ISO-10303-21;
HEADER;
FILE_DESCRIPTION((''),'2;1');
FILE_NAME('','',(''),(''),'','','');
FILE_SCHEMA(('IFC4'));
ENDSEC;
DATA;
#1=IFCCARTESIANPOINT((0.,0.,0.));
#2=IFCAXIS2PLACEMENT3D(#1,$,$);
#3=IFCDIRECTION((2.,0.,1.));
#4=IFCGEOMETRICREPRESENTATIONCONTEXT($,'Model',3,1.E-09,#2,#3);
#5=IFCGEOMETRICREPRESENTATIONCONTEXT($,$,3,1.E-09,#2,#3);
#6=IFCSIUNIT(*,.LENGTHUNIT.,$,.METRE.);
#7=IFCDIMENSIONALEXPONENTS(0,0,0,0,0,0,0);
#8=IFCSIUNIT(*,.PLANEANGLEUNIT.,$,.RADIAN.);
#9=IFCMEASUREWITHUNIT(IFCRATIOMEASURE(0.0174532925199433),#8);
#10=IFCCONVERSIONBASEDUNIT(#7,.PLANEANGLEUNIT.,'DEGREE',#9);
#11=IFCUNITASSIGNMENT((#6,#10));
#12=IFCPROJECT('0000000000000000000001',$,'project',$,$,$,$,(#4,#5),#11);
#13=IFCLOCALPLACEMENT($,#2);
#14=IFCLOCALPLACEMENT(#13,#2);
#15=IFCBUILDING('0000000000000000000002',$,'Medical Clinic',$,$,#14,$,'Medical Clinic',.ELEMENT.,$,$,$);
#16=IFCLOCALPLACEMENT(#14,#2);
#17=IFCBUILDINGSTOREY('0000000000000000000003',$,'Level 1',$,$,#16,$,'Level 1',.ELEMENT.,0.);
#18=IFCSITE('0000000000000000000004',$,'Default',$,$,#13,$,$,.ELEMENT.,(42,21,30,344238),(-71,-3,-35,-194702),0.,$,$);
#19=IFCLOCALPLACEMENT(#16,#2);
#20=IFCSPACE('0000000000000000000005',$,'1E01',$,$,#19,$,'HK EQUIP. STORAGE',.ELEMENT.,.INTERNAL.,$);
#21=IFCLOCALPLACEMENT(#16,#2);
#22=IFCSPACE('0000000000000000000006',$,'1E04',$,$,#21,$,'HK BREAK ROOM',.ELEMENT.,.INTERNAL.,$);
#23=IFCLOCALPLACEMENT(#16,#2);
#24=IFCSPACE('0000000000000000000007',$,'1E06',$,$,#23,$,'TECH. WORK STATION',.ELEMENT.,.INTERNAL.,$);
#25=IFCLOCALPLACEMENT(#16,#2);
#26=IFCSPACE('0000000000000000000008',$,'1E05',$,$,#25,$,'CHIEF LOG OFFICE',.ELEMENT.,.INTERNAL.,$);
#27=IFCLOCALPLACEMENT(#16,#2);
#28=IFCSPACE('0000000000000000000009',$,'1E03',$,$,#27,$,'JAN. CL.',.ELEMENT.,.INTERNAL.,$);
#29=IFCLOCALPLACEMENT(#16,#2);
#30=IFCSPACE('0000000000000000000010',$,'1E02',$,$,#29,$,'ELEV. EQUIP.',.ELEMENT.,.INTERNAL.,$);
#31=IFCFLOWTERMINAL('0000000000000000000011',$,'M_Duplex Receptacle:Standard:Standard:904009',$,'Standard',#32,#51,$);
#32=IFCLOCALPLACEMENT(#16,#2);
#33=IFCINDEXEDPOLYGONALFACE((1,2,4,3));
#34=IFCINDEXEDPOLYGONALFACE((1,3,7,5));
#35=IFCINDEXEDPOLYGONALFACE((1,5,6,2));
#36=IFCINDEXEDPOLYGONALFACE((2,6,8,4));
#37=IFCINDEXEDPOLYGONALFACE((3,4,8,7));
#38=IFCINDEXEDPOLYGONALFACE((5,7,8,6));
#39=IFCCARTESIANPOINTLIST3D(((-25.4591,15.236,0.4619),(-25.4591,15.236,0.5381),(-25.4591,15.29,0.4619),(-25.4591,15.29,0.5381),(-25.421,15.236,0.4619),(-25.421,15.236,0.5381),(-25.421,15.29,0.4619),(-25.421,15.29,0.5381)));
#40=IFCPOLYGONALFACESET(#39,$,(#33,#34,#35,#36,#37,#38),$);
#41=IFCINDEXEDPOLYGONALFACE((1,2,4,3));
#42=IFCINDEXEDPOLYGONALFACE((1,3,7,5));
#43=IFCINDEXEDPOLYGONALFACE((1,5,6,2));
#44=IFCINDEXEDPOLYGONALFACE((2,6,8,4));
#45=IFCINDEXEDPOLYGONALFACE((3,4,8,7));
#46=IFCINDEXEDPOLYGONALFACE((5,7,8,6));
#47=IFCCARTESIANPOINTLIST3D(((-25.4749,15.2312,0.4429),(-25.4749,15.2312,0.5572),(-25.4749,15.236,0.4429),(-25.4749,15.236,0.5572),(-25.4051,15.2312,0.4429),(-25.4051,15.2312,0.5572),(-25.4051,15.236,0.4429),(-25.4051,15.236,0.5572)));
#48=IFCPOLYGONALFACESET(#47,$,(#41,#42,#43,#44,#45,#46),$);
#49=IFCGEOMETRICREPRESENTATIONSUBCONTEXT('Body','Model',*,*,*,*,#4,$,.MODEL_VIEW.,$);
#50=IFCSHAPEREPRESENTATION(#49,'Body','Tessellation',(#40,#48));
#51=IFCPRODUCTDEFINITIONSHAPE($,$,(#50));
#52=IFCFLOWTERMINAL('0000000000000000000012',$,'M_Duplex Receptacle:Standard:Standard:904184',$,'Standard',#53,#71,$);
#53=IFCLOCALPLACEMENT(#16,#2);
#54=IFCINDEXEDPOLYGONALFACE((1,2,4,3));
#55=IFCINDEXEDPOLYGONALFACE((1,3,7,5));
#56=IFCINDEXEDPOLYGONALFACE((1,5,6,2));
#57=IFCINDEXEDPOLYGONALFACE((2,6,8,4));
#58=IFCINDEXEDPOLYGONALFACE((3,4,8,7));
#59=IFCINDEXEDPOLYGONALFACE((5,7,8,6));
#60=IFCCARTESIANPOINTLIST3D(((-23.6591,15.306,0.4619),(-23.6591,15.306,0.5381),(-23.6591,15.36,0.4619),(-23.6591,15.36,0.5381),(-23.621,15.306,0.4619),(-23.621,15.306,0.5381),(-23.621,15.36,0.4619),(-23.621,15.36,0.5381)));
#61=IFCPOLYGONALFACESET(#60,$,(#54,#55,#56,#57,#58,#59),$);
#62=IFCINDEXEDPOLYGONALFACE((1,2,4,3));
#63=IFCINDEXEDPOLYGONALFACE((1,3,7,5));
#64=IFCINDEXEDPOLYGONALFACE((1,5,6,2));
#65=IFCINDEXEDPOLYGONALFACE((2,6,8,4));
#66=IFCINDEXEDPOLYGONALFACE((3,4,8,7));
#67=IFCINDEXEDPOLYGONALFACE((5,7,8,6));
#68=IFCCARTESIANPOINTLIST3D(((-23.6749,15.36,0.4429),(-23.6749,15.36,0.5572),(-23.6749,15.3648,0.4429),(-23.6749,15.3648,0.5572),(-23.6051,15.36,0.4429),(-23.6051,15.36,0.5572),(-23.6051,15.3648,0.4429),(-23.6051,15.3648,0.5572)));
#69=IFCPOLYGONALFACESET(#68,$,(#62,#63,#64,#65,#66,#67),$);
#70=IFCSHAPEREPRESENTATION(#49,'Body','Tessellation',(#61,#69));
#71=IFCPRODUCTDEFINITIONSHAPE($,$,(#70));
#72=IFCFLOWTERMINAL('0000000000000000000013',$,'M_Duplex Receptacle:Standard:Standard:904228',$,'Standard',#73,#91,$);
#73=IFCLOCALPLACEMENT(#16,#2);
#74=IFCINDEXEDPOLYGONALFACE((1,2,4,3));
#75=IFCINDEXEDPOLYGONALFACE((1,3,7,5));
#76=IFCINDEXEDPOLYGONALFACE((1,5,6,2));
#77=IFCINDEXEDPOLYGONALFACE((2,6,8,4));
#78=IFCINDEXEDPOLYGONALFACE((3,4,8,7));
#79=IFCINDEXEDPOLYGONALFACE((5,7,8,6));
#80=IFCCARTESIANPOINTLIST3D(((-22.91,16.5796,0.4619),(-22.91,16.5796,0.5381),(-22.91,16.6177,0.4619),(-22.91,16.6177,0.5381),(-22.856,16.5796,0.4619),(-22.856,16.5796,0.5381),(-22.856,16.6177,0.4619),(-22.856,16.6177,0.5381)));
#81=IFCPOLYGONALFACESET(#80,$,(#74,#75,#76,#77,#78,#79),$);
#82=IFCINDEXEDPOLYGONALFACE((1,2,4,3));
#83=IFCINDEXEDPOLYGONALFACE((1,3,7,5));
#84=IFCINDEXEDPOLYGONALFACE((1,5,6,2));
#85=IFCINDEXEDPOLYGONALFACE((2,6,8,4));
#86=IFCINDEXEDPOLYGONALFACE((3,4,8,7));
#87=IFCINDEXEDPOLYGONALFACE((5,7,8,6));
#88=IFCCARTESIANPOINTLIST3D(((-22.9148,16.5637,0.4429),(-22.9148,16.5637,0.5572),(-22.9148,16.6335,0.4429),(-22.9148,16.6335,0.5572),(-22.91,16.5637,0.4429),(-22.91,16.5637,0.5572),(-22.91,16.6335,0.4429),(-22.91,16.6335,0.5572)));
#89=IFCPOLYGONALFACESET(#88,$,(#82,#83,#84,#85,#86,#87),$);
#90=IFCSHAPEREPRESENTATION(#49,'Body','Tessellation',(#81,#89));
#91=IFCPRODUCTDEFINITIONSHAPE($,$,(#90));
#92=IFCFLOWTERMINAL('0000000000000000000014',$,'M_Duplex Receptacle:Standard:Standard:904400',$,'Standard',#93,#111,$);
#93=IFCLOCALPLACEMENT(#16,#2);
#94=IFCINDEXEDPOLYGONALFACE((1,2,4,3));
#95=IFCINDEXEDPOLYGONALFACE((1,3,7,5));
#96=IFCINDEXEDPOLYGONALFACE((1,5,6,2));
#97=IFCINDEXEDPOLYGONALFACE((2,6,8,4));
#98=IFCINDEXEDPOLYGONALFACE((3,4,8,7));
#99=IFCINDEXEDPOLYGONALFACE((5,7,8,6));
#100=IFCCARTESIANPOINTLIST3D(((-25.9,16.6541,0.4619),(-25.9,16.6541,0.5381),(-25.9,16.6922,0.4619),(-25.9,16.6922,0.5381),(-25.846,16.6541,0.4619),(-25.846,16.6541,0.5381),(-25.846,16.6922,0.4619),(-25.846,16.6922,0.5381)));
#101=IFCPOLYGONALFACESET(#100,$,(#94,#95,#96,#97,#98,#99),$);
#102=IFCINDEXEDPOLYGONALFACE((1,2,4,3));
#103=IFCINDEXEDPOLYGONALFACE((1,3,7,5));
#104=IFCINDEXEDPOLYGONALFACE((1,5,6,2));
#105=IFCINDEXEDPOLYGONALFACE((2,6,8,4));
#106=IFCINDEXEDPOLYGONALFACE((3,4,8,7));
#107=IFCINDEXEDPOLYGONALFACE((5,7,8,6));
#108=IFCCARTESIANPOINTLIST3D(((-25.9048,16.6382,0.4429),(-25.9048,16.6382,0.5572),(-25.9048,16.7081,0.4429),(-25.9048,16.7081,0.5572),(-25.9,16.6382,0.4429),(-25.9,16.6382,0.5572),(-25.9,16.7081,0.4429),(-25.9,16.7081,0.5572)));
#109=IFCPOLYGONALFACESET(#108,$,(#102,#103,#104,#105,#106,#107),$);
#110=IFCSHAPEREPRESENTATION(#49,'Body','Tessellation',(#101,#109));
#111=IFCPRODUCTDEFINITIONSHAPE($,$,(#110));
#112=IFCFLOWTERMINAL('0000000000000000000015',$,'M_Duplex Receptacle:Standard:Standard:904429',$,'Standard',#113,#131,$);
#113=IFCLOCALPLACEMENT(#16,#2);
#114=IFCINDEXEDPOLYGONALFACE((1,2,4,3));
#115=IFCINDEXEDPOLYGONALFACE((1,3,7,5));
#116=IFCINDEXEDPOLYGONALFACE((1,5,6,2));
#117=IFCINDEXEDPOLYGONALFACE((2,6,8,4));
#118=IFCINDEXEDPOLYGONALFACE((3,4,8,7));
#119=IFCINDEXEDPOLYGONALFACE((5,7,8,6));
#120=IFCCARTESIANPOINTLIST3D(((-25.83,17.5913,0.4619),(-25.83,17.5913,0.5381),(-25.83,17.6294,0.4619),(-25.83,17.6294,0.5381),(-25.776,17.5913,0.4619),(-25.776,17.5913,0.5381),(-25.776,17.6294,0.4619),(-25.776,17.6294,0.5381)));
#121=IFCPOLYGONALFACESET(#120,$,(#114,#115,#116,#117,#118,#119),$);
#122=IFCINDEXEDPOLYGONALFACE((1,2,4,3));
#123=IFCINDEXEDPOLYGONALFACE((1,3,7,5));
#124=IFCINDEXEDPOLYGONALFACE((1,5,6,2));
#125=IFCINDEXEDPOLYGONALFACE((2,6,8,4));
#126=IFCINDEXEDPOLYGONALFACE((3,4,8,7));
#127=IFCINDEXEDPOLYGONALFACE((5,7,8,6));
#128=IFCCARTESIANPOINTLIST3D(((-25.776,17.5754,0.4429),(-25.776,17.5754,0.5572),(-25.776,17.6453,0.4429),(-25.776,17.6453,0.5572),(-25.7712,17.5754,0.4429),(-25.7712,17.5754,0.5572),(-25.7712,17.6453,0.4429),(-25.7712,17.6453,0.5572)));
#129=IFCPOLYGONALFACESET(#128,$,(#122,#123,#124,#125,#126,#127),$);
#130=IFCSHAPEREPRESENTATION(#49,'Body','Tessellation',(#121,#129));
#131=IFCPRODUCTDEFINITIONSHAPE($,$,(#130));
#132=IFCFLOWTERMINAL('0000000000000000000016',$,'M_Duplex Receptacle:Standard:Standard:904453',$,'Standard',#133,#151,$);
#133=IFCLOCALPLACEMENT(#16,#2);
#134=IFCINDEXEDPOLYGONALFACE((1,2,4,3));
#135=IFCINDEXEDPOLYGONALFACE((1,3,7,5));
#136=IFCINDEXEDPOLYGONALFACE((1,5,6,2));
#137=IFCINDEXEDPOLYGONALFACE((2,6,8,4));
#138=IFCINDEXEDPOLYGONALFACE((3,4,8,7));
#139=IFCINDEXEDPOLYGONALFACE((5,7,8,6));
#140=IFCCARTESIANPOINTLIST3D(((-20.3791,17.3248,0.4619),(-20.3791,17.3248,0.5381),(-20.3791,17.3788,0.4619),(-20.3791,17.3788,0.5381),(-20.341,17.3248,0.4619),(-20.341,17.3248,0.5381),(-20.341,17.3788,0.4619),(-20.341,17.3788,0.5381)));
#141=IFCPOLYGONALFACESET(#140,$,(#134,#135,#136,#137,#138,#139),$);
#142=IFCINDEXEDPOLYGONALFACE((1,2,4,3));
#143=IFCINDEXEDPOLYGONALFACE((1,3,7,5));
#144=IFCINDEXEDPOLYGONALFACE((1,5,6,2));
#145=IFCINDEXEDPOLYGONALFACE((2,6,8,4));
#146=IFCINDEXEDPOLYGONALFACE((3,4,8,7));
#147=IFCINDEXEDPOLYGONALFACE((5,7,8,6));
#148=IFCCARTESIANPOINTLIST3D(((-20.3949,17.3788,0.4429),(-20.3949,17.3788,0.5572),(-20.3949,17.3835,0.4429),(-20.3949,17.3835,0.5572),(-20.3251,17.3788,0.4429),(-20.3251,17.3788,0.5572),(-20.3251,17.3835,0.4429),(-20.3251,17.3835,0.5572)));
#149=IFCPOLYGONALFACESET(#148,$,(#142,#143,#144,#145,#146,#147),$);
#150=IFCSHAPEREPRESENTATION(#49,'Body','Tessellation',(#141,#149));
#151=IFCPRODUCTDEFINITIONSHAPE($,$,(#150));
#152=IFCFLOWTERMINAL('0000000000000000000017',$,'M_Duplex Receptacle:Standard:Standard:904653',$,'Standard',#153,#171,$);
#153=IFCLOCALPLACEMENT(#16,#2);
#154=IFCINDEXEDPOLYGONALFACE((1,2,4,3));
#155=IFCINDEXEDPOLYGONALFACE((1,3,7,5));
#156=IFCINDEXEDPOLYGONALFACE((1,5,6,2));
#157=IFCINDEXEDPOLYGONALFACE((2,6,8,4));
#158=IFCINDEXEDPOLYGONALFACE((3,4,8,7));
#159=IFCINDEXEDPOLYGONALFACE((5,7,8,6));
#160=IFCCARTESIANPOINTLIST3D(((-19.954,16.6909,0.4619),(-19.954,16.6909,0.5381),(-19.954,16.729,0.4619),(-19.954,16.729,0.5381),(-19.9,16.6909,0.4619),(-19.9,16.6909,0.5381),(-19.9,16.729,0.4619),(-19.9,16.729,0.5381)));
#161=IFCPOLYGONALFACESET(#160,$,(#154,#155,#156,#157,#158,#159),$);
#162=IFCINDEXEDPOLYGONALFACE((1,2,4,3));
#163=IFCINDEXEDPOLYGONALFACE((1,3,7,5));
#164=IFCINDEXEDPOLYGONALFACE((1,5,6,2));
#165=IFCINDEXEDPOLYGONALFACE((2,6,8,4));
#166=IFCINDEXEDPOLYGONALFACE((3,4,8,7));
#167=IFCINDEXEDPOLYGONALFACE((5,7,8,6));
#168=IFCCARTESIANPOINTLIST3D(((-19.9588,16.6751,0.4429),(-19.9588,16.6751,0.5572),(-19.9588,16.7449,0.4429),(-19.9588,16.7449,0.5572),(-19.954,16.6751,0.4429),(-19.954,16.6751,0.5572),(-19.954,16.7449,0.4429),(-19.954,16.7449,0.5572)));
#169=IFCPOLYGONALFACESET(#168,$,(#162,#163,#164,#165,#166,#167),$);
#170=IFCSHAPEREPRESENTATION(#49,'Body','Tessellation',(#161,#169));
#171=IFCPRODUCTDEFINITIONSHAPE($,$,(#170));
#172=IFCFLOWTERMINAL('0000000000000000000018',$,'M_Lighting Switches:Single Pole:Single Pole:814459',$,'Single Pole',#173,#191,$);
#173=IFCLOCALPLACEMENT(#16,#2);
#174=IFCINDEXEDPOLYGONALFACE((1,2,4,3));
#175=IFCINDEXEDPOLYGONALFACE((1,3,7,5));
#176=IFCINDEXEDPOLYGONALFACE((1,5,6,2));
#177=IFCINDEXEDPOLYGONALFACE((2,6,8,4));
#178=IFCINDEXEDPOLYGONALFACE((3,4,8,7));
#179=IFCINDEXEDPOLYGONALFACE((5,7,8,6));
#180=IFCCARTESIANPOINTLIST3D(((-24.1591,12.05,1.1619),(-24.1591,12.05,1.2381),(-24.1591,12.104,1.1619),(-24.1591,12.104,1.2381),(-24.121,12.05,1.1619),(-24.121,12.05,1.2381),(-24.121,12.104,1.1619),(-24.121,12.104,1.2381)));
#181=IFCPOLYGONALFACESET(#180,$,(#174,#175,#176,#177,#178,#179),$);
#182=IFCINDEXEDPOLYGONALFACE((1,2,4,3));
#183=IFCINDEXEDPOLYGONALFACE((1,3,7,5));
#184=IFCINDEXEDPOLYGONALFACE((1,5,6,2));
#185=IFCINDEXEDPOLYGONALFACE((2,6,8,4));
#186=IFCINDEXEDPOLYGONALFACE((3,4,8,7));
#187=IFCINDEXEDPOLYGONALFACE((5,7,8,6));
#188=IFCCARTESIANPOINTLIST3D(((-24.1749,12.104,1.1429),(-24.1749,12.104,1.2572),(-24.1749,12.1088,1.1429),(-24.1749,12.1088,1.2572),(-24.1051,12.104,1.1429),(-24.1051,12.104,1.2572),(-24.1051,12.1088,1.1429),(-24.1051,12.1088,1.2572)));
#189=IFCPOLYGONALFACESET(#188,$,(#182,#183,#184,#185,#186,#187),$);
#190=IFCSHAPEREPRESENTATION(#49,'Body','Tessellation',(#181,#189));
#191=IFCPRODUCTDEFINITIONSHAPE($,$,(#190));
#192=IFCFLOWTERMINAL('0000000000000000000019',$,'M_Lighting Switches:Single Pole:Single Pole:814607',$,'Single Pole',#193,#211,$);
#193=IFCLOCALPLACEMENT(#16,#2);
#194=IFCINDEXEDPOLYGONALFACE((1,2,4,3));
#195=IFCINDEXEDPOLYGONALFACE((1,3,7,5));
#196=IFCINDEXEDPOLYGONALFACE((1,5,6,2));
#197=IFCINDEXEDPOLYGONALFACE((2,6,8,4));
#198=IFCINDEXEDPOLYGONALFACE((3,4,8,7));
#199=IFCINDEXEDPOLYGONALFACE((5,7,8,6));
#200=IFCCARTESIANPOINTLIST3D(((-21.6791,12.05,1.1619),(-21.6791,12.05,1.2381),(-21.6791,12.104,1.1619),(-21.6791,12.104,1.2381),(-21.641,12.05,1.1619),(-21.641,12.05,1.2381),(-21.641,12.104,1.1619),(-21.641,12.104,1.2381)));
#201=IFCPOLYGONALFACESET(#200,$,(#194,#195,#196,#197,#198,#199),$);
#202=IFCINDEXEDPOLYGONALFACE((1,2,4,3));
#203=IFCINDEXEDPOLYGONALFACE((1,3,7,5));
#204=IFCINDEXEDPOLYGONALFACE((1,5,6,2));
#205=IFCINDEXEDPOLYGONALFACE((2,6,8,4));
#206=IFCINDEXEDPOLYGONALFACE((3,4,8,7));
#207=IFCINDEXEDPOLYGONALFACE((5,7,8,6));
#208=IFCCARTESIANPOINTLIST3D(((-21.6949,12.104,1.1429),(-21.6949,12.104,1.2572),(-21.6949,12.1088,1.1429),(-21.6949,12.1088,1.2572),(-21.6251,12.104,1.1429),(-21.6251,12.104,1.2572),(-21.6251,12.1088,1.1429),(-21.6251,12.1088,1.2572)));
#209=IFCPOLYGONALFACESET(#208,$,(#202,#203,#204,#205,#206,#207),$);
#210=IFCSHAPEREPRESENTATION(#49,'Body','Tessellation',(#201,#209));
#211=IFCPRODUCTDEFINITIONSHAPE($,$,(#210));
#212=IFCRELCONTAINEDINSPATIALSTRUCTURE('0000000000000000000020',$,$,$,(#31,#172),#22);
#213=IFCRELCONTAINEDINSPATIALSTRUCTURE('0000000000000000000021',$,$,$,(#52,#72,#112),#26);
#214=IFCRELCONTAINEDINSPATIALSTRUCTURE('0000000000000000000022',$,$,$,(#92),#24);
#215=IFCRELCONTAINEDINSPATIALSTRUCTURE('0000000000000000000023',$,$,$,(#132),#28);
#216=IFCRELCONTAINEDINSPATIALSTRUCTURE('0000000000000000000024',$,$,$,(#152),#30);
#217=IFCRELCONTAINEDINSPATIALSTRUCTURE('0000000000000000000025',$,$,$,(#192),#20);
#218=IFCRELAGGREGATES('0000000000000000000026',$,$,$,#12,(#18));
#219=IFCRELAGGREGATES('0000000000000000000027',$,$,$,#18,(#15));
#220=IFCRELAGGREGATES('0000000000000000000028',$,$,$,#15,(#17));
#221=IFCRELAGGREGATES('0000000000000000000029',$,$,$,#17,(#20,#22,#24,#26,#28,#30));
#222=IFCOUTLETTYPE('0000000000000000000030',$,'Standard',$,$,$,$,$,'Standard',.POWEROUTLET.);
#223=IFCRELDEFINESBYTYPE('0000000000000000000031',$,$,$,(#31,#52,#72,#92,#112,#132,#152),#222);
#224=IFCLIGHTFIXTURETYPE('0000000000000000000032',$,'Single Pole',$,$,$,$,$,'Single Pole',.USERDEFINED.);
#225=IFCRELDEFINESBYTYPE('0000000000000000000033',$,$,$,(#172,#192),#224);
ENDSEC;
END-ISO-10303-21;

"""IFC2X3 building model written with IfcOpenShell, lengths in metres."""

from ifc_helpers import new_model, entity, si_unit, converted_unit, direction, frame, frame_2d, origin, origin_2d_with_axis, place, context, subcontext, project, spatial, rectangle, extrude, source, transform, mapped, type_object, type_shapes, element, save


model = new_model("IFC2X3")

# Units and contexts
model_context = context("Model", 3, precision=1e-09, world=origin(), true_north=direction((2.0, 0.0, 1.0)))
context_of_model = context(None, 3, precision=1e-09, world=origin(), true_north=direction((2.0, 0.0, 1.0)))
body_context = subcontext(model_context, "Body", "Model", "MODEL_VIEW")
ifc_project = project(units=[si_unit("LENGTHUNIT", "METRE"), converted_unit("PLANEANGLEUNIT", "DEGREE", entity("IfcRatioMeasure", 0.0174532925199433), si_unit("PLANEANGLEUNIT", "RADIAN"), dimensions=[0, 0, 0, 0, 0, 0, 0])], contexts=[model_context, context_of_model])

# Site, building, storey
site_placement = place(None, origin())
site = spatial("IfcSite", under=ifc_project, at=site_placement, Name="Default", CompositionType="ELEMENT", RefLatitude=(42, 21, 30, 344238), RefLongitude=(-71, -3, -35, -194702), RefElevation=0.0)
building_placement = place(site_placement, origin())
building = spatial("IfcBuilding", under=site, at=building_placement, Name="Medical Clinic", LongName="Medical Clinic", CompositionType="ELEMENT")
storey_placement = place(building_placement, origin())
storey = spatial("IfcBuildingStorey", under=building, at=storey_placement, Name="Level 1", LongName="Level 1", CompositionType="ELEMENT", Elevation=0.0)

# Shared definitions
outlet_type = type_object("IfcOutletType", Name="Standard", ElementType="Standard", PredefinedType="POWEROUTLET")
shared_shape_1 = source(origin(), body_context, "Body", "SweptSolid", [
    extrude(rectangle(XDim=0.0381, YDim=0.0762, at=origin_2d_with_axis()), frame((0.0, 0.0, -0.054), z_axis=(0.0, 0.0, 1.0), x_axis=(-1.0, 0.0, 0.0)), (0.0, 0.0, 1.0), 0.054),
    extrude(rectangle(XDim=0.0698, YDim=0.1143, at=frame_2d((0.0, 0.0), x_axis=(1.0, 0.0))), frame((0.0, 0.0, 0.0), z_axis=(0.0, 0.0, 1.0), x_axis=(-1.0, 0.0, 0.0)), (0.0, 0.0, 1.0), 0.0048),
])
type_shapes(outlet_type, [shared_shape_1])

# Shared definitions
space_1_placement = place(storey_placement, origin())
space_1 = spatial("IfcSpace", under=storey, at=space_1_placement, Name="1E01", LongName="HK EQUIP. STORAGE", CompositionType="ELEMENT", InteriorOrExteriorSpace="INTERNAL")

# Shared definitions
space_2_placement = place(storey_placement, origin())
space_2 = spatial("IfcSpace", under=storey, at=space_2_placement, Name="1E04", LongName="HK BREAK ROOM", CompositionType="ELEMENT", InteriorOrExteriorSpace="INTERNAL")

# Shared definitions
space_3_placement = place(storey_placement, origin())
space_3 = spatial("IfcSpace", under=storey, at=space_3_placement, Name="1E06", LongName="TECH. WORK STATION", CompositionType="ELEMENT", InteriorOrExteriorSpace="INTERNAL")

# Flow terminal
for number, where, z_axis, x_axis, name in (
    (1, (-25.44, 15.236, 0.5), (0.0, -1.0, 0.0), (1.0, 0.0, 0.0), "M_Duplex Receptacle:Standard:Standard:904009"),
):
    element("IfcFlowTerminal", number, at=place(space_2_placement, frame(where, z_axis=z_axis, x_axis=x_axis)), inside=space_2, type_object=outlet_type, Name=name, ObjectType="Standard", context=body_context, shape_type="MappedRepresentation", body=[
        mapped(shared_shape_1, transform((0.0, 0.0, 0.0), scale=1.0)),
    ])

# Shared definitions
space_4_placement = place(storey_placement, origin())
space_4 = spatial("IfcSpace", under=storey, at=space_4_placement, Name="1E05", LongName="CHIEF LOG OFFICE", CompositionType="ELEMENT", InteriorOrExteriorSpace="INTERNAL")

# Flow terminals
for number, where, z_axis, x_axis, name in (
    (2, (-23.64, 15.36, 0.5), (0.0, 1.0, 0.0), (-1.0, 0.0, 0.0), "M_Duplex Receptacle:Standard:Standard:904184"),
    (3, (-22.91, 16.5986, 0.5), (-1.0, 0.0, 0.0), (0.0, -1.0, 0.0), "M_Duplex Receptacle:Standard:Standard:904228"),
):
    element("IfcFlowTerminal", number, at=place(space_4_placement, frame(where, z_axis=z_axis, x_axis=x_axis)), inside=space_4, type_object=outlet_type, Name=name, ObjectType="Standard", context=body_context, shape_type="MappedRepresentation", body=[
        mapped(shared_shape_1, transform((0.0, 0.0, 0.0), scale=1.0)),
    ])
flow_terminal_1_placement = place(space_3_placement, frame((-25.9, 16.6732, 0.5), z_axis=(-1.0, 0.0, 0.0), x_axis=(0.0, -1.0, 0.0)))
element("IfcFlowTerminal", 4, at=flow_terminal_1_placement, inside=space_3, type_object=outlet_type, Name="M_Duplex Receptacle:Standard:Standard:904400", ObjectType="Standard", context=body_context, shape_type="MappedRepresentation", body=[
    mapped(shared_shape_1, transform((0.0, 0.0, 0.0), scale=1.0)),
])
flow_terminal_2_placement = place(space_4_placement, frame((-25.776, 17.6103, 0.5), z_axis=(1.0, 0.0, 0.0), x_axis=(0.0, 1.0, 0.0)))
element("IfcFlowTerminal", 5, at=flow_terminal_2_placement, inside=space_4, type_object=outlet_type, Name="M_Duplex Receptacle:Standard:Standard:904429", ObjectType="Standard", context=body_context, shape_type="MappedRepresentation", body=[
    mapped(shared_shape_1, transform((0.0, 0.0, 0.0), scale=1.0)),
])

# Shared definitions
space_5_placement = place(storey_placement, origin())
space_5 = spatial("IfcSpace", under=storey, at=space_5_placement, Name="1E03", LongName="JAN. CL.", CompositionType="ELEMENT", InteriorOrExteriorSpace="INTERNAL")

# Flow terminal
flow_terminal_3_placement = place(space_5_placement, frame((-20.36, 17.3788, 0.5), z_axis=(0.0, 1.0, 0.0), x_axis=(-1.0, 0.0, 0.0)))
element("IfcFlowTerminal", 6, at=flow_terminal_3_placement, inside=space_5, type_object=outlet_type, Name="M_Duplex Receptacle:Standard:Standard:904453", ObjectType="Standard", context=body_context, shape_type="MappedRepresentation", body=[
    mapped(shared_shape_1, transform((0.0, 0.0, 0.0), scale=1.0)),
])

# Shared definitions
space_6_placement = place(storey_placement, origin())
space_6 = spatial("IfcSpace", under=storey, at=space_6_placement, Name="1E02", LongName="ELEV. EQUIP.", CompositionType="ELEMENT", InteriorOrExteriorSpace="INTERNAL")

# Flow terminals
flow_terminal_4_placement = place(space_6_placement, frame((-19.954, 16.71, 0.5), z_axis=(-1.0, 0.0, 0.0), x_axis=(0.0, -1.0, 0.0)))
element("IfcFlowTerminal", 7, at=flow_terminal_4_placement, inside=space_6, type_object=outlet_type, Name="M_Duplex Receptacle:Standard:Standard:904653", ObjectType="Standard", context=body_context, shape_type="MappedRepresentation", body=[
    mapped(shared_shape_1, transform((0.0, 0.0, 0.0), scale=1.0)),
])
light_fixture_type_1 = type_object("IfcLightFixtureType", Name="Single Pole", ElementType="Single Pole", PredefinedType="USERDEFINED")
shared_shape_2 = source(origin(), body_context, "Body", "SweptSolid", [
    extrude(rectangle(XDim=0.0381, YDim=0.0762, at=origin_2d_with_axis()), frame((0.0, 0.0, -0.054), z_axis=(0.0, 0.0, 1.0), x_axis=(-1.0, 0.0, 0.0)), (0.0, 0.0, 1.0), 0.054),
    extrude(rectangle(XDim=0.0698, YDim=0.1143, at=frame_2d((0.0, 0.0), x_axis=(1.0, 0.0))), frame((0.0, 0.0, 0.0), z_axis=(0.0, 0.0, 1.0), x_axis=(-1.0, 0.0, 0.0)), (0.0, 0.0, 1.0), 0.0048),
])
type_shapes(light_fixture_type_1, [shared_shape_2])
flow_terminal_5_placement = place(space_2_placement, frame((-24.14, 12.104, 1.2), z_axis=(0.0, 1.0, 0.0), x_axis=(-1.0, 0.0, 0.0)))
element("IfcFlowTerminal", 8, at=flow_terminal_5_placement, inside=space_2, type_object=light_fixture_type_1, Name="M_Lighting Switches:Single Pole:Single Pole:814459", ObjectType="Single Pole", context=body_context, shape_type="MappedRepresentation", body=[
    mapped(shared_shape_2, transform((0.0, 0.0, 0.0), scale=1.0)),
])
flow_terminal_6_placement = place(space_1_placement, frame((-21.66, 12.104, 1.2), z_axis=(0.0, 1.0, 0.0), x_axis=(-1.0, 0.0, 0.0)))
element("IfcFlowTerminal", 9, at=flow_terminal_6_placement, inside=space_1, type_object=light_fixture_type_1, Name="M_Lighting Switches:Single Pole:Single Pole:814607", ObjectType="Single Pole", context=body_context, shape_type="MappedRepresentation", body=[
    mapped(shared_shape_2, transform((0.0, 0.0, 0.0), scale=1.0)),
])

save(model, "model.ifc")
